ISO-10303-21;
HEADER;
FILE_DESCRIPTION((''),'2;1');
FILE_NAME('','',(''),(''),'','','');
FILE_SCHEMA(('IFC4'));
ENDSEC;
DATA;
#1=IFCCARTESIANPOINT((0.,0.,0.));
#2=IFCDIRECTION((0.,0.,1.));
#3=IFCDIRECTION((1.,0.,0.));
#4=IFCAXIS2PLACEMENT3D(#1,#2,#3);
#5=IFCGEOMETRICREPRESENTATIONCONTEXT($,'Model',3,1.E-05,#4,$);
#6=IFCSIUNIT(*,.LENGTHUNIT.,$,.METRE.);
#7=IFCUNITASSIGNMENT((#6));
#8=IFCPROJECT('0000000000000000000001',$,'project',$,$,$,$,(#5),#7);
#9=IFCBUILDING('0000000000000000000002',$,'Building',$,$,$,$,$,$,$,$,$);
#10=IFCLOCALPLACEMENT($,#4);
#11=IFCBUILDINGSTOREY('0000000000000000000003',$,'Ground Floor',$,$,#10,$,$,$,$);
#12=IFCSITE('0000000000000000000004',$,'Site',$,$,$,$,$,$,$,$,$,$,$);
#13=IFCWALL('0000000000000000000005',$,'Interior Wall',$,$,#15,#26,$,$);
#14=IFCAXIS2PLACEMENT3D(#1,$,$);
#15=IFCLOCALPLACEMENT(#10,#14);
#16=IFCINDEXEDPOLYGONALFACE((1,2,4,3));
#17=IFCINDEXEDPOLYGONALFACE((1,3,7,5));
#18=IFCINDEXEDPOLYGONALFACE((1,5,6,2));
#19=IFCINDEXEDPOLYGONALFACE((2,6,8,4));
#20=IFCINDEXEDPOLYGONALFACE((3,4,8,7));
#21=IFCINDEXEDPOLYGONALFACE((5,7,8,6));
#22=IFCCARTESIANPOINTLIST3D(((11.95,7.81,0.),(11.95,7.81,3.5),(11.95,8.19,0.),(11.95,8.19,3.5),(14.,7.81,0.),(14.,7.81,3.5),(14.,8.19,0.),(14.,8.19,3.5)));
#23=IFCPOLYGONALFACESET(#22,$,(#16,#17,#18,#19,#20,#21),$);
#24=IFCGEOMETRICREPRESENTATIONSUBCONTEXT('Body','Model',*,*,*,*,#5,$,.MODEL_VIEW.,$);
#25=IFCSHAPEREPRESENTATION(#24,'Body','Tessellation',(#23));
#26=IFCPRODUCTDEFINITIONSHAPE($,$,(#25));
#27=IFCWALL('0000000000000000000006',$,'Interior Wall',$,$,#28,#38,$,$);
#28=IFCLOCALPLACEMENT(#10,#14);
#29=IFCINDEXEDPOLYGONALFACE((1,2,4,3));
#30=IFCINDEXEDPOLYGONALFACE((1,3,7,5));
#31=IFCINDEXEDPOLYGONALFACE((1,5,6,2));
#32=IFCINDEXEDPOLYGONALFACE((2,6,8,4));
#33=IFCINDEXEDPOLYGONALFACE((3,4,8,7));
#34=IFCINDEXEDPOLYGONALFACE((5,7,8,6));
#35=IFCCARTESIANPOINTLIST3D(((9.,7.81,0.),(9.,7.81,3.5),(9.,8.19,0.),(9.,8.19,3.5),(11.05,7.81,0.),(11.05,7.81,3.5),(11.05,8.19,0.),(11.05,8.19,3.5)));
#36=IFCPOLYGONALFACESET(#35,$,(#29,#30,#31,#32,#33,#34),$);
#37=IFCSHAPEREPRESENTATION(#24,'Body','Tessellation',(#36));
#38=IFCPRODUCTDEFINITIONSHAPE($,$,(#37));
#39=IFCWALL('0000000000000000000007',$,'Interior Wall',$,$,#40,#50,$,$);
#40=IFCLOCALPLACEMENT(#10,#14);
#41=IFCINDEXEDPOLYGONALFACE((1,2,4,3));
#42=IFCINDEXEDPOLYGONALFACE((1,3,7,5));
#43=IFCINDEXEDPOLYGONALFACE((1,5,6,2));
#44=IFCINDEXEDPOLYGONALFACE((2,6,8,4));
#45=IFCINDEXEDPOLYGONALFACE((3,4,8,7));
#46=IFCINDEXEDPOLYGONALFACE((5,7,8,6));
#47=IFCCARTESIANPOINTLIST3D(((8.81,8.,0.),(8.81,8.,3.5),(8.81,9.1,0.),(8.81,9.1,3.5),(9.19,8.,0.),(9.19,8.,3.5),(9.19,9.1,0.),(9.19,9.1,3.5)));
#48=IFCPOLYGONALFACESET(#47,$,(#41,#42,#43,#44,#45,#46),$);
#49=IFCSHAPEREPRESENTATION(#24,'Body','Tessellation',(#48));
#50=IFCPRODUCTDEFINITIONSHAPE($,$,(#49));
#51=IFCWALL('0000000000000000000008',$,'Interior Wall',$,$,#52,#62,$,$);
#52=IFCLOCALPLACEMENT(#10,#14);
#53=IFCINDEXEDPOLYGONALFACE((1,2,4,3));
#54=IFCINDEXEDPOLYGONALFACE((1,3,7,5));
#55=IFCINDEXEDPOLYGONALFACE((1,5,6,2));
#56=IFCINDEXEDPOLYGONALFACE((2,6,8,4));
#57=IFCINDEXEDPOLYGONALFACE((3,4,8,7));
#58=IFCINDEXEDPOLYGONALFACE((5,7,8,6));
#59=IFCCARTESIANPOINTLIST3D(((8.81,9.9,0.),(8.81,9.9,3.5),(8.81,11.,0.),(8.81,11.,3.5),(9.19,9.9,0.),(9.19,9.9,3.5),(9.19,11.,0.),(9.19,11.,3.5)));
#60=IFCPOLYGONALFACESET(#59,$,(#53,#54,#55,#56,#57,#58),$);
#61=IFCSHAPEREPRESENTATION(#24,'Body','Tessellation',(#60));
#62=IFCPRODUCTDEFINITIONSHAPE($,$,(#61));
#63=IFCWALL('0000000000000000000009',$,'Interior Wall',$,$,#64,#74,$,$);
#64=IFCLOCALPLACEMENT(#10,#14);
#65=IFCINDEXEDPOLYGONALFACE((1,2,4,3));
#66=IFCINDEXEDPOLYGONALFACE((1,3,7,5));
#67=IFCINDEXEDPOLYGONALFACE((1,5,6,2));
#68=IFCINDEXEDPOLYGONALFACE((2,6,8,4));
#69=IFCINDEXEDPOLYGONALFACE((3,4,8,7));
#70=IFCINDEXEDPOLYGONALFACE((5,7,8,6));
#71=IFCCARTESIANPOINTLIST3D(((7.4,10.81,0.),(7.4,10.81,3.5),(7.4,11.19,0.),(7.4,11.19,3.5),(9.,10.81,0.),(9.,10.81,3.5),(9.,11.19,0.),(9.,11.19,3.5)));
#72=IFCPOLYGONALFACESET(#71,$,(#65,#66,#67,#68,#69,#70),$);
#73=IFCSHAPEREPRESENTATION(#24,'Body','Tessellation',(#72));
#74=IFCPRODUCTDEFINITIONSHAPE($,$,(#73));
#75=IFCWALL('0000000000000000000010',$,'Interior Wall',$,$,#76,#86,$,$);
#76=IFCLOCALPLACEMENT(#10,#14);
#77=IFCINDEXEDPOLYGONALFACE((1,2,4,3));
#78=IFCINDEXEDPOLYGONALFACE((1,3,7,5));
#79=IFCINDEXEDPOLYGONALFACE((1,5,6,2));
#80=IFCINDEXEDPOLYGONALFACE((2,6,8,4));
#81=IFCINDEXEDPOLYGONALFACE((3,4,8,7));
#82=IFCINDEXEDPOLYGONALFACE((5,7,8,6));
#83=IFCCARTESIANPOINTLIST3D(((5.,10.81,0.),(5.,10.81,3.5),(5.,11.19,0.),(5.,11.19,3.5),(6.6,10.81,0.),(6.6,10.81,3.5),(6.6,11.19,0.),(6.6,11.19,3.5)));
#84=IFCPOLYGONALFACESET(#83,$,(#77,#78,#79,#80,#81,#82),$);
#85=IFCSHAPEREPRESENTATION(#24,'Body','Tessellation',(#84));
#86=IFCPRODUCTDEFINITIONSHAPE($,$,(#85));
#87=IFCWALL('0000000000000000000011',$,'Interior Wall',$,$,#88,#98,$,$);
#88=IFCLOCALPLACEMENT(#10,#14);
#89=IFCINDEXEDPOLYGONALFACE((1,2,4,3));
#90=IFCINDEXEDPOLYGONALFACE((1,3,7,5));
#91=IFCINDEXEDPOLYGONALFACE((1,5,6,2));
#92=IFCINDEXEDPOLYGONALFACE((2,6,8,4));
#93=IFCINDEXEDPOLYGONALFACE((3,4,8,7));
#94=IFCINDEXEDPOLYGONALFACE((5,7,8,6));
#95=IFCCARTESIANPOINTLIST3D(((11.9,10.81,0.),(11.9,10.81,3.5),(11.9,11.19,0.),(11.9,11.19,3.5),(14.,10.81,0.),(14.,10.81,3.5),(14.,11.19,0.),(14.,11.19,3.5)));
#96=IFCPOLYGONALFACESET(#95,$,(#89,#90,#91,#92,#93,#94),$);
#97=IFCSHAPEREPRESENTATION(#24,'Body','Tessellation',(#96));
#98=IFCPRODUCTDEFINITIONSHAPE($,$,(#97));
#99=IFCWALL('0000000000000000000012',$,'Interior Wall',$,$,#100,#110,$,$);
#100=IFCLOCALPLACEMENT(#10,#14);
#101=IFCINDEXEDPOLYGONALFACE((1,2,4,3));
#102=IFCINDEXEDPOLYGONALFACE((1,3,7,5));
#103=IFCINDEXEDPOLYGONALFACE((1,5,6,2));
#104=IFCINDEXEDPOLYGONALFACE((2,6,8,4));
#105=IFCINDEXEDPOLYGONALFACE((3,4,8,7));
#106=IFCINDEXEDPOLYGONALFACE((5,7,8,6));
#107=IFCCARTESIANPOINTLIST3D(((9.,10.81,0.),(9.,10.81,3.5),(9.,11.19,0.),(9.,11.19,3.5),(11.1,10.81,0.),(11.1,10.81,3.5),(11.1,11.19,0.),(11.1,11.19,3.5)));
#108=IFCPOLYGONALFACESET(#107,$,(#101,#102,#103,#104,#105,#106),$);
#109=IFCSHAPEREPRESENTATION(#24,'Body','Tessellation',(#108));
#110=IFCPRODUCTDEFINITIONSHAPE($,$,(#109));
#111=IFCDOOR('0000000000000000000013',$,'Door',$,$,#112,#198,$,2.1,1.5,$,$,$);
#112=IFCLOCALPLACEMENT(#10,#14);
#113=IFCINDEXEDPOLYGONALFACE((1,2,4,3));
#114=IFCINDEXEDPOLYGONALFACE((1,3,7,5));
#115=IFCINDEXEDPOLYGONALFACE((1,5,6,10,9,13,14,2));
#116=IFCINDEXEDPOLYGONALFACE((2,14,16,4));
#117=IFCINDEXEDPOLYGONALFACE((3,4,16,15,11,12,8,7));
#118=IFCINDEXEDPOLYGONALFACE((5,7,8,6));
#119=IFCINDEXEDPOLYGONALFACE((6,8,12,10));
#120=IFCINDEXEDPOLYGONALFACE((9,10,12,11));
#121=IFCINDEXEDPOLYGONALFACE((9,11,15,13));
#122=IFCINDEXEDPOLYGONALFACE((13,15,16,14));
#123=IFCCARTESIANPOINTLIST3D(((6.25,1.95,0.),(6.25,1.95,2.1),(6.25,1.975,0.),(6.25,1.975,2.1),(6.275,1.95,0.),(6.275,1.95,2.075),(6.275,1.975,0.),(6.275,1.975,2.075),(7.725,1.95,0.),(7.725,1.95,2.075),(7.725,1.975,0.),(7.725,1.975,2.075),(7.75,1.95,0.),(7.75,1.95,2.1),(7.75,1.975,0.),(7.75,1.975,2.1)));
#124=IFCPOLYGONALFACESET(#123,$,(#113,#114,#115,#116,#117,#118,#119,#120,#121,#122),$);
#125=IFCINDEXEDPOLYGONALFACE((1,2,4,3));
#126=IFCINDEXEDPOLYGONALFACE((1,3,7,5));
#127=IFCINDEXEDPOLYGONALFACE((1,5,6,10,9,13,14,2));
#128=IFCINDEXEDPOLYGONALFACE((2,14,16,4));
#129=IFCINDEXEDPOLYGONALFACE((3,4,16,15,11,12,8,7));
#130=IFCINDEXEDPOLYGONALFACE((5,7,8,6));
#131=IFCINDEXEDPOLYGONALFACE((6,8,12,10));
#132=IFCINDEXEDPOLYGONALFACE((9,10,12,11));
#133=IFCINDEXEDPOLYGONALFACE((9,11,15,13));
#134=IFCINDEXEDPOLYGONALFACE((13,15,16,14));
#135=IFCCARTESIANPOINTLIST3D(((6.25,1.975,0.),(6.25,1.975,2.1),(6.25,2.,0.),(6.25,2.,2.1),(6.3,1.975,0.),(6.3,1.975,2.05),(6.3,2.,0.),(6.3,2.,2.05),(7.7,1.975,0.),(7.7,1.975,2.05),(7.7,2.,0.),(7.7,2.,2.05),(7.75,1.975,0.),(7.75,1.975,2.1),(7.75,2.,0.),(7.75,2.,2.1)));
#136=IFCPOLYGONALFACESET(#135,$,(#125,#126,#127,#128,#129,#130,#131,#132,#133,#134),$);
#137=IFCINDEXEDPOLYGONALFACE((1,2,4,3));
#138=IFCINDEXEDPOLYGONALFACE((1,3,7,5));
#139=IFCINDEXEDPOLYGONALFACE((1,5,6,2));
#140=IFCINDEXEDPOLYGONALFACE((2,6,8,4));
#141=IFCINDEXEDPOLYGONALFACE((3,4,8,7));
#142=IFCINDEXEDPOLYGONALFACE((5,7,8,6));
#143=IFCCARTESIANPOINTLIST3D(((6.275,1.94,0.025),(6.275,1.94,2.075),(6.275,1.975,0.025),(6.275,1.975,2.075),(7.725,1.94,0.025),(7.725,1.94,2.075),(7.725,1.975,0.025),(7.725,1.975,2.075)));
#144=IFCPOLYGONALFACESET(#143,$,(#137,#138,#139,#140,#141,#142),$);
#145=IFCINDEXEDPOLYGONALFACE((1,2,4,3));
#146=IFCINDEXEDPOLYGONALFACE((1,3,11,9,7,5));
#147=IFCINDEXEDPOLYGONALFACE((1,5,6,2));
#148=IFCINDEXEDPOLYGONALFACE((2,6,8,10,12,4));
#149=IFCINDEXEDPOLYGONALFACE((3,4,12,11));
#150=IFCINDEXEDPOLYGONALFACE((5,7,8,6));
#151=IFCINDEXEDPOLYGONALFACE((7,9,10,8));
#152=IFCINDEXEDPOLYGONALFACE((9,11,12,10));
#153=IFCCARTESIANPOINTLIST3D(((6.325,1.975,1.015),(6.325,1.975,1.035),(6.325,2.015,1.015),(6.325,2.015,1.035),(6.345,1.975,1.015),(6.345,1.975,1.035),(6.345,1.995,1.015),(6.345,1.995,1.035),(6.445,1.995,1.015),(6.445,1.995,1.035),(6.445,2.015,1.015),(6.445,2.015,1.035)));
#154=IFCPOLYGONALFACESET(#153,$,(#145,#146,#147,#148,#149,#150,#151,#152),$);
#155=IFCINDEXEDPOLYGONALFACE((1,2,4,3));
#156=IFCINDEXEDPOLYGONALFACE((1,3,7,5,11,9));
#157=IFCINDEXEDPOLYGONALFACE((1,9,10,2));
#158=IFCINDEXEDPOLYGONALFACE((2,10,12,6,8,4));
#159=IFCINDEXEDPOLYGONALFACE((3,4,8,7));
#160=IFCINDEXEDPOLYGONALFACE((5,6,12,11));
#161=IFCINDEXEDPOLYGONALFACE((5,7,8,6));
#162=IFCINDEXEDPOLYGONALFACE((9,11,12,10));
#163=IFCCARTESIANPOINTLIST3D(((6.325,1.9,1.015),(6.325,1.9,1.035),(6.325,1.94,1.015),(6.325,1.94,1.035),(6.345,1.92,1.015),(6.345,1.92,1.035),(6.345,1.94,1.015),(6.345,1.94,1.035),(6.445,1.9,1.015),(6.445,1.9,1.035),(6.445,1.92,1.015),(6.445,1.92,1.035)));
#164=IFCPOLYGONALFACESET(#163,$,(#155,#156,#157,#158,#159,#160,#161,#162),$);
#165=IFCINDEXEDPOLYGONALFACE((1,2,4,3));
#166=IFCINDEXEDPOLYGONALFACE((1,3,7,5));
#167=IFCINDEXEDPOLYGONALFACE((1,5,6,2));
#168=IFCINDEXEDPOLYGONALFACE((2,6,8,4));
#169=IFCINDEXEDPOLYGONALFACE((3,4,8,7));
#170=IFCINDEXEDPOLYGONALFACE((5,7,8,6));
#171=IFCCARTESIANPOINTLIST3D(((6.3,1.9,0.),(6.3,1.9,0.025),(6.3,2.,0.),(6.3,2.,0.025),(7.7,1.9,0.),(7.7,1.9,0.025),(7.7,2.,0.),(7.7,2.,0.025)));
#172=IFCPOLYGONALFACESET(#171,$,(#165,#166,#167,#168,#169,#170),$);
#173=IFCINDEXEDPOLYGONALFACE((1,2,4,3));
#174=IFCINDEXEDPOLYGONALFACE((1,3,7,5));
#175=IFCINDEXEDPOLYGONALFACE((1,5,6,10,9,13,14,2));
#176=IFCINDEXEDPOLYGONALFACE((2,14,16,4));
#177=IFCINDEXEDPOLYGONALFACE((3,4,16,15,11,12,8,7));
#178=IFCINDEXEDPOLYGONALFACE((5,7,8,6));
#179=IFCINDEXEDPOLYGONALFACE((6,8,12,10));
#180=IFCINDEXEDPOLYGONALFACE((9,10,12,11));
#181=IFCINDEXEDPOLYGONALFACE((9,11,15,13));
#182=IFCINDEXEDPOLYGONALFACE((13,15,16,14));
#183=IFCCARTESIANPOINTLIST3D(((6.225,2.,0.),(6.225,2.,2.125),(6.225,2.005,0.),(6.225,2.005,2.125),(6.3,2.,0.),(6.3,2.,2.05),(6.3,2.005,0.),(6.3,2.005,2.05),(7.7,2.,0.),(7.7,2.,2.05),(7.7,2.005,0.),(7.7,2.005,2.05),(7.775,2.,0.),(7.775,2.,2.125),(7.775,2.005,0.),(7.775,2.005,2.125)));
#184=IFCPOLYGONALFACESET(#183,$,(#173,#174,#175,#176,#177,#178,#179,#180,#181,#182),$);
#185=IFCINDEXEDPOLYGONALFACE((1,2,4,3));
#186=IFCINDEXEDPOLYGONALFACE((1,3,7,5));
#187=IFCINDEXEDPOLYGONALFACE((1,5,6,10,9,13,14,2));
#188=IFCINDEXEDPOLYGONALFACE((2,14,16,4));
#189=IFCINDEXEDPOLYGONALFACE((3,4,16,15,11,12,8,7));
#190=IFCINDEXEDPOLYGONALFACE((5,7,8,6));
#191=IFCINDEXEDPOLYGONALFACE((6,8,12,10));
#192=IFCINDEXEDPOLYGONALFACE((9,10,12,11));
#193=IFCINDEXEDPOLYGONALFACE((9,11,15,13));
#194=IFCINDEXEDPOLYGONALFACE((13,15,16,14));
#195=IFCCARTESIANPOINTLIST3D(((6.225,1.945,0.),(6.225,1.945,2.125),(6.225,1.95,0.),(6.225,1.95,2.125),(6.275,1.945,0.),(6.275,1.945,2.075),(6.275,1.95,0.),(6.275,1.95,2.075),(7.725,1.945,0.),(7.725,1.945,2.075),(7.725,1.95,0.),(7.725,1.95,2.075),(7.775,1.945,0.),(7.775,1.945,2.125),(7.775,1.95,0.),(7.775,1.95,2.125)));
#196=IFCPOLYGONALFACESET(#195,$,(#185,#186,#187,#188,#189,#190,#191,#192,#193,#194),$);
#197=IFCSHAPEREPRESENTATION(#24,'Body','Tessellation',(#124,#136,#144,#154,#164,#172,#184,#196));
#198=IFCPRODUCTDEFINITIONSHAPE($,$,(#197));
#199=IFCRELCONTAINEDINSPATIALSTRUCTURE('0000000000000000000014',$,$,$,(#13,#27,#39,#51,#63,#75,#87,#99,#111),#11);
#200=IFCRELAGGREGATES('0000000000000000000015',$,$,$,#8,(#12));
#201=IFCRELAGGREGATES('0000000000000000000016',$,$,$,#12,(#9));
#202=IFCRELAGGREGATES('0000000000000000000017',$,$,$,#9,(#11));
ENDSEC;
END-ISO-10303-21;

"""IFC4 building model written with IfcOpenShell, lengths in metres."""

from ifc_helpers import new_model, si_unit, frame, origin_with_axes, place, context, subcontext, project, spatial, line, indexed_curve, outline, extrude, element, save


model = new_model("IFC4")

# Units and contexts
model_context = context("Model", 3, precision=1e-05, world=origin_with_axes())
body_context = subcontext(model_context, "Body", "Model", "MODEL_VIEW")
ifc_project = project(units=[si_unit("LENGTHUNIT", "METRE")], contexts=[model_context])

# Site, building, storey
site = spatial("IfcSite", under=ifc_project, Name="Site")
building = spatial("IfcBuilding", under=site, Name="Building")
storey_placement = place(None, origin_with_axes())
storey = spatial("IfcBuildingStorey", under=building, at=storey_placement, Name="Ground Floor")

# Walls
for number, where, z_axis, x_axis, name in (
    (1, (14.0, 8.0, 0.0), (0.0, 0.0, 1.0), (-1.0, 0.0, 0.0), "Interior Wall"),
    (2, (11.05, 8.0, 0.0), (0.0, 0.0, 1.0), (-1.0, 0.0, 0.0), "Interior Wall"),
):
    element("IfcWall", number, at=place(storey_placement, frame(where, z_axis=z_axis, x_axis=x_axis)), inside=storey, Name=name, context=body_context, shape_type="SweptSolid", body=[
        extrude(outline(indexed_curve([(0.0, 0.0), (0.0, 0.38), (2.05, 0.38), (2.05, 0.0), (0.0, 0.0)], self_intersect=False)), frame((0.0, -0.19, 0.0), z_axis=(0.0, 0.0, 1.0), x_axis=(1.0, 0.0, 0.0)), (0.0, 0.0, 1.0), 3.5),
    ])
for number, where, z_axis, x_axis, name in (
    (3, (9.0, 8.0, 0.0), (0.0, 0.0, 1.0), (0.0, 1.0, 0.0), "Interior Wall"),
    (4, (9.0, 9.9, 0.0), (0.0, 0.0, 1.0), (0.0, 1.0, 0.0), "Interior Wall"),
):
    element("IfcWall", number, at=place(storey_placement, frame(where, z_axis=z_axis, x_axis=x_axis)), inside=storey, Name=name, context=body_context, shape_type="SweptSolid", body=[
        extrude(outline(indexed_curve([(0.0, 0.0), (0.0, 0.38), (1.1, 0.38), (1.1, 0.0), (0.0, 0.0)], self_intersect=False)), frame((0.0, -0.19, 0.0), z_axis=(0.0, 0.0, 1.0), x_axis=(1.0, 0.0, 0.0)), (0.0, 0.0, 1.0), 3.5),
    ])
for number, where, z_axis, x_axis, name in (
    (5, (9.0, 11.0, 0.0), (0.0, 0.0, 1.0), (-1.0, 0.0, 0.0), "Interior Wall"),
    (6, (6.6, 11.0, 0.0), (0.0, 0.0, 1.0), (-1.0, 0.0, 0.0), "Interior Wall"),
):
    element("IfcWall", number, at=place(storey_placement, frame(where, z_axis=z_axis, x_axis=x_axis)), inside=storey, Name=name, context=body_context, shape_type="SweptSolid", body=[
        extrude(outline(indexed_curve([(0.0, 0.0), (0.0, 0.38), (1.6, 0.38), (1.6, 0.0), (0.0, 0.0)], self_intersect=False)), frame((0.0, -0.19, 0.0), z_axis=(0.0, 0.0, 1.0), x_axis=(1.0, 0.0, 0.0)), (0.0, 0.0, 1.0), 3.5),
    ])
for number, where, z_axis, x_axis, name in (
    (7, (14.0, 11.0, 0.0), (0.0, 0.0, 1.0), (-1.0, 0.0, 0.0), "Interior Wall"),
    (8, (11.1, 11.0, 0.0), (0.0, 0.0, 1.0), (-1.0, 0.0, 0.0), "Interior Wall"),
):
    element("IfcWall", number, at=place(storey_placement, frame(where, z_axis=z_axis, x_axis=x_axis)), inside=storey, Name=name, context=body_context, shape_type="SweptSolid", body=[
        extrude(outline(indexed_curve([(0.0, 0.0), (0.0, 0.38), (2.1, 0.38), (2.1, 0.0), (0.0, 0.0)], self_intersect=False)), frame((0.0, -0.19, 0.0), z_axis=(0.0, 0.0, 1.0), x_axis=(1.0, 0.0, 0.0)), (0.0, 0.0, 1.0), 3.5),
    ])

# Door
door_1_placement = place(storey_placement, frame((7.75, 2.0, 0.0), z_axis=(0.0, 0.0, 1.0), x_axis=(-1.0, 0.0, 0.0)))
element("IfcDoor", 9, at=door_1_placement, inside=storey, Name="Door", OverallHeight=2.1, OverallWidth=1.5, context=body_context, shape_type="SweptSolid", body=[
    extrude(outline(indexed_curve([(0.0, 0.0), (0.0, 2.1), (1.5, 2.1), (1.5, 0.0), (1.475, 0.0), (1.475, 2.075), (0.025, 2.075), (0.025, 0.0)], segments=[line(1, 2, 3, 4, 5, 6, 7, 8, 1)])), frame((0.0, 0.025, 0.0), z_axis=(0.0, -1.0, 0.0), x_axis=(1.0, 0.0, 0.0)), (0.0, 0.0, -1.0), 0.025),
    extrude(outline(indexed_curve([(0.0, 0.0), (0.0, 2.1), (1.5, 2.1), (1.5, 0.0), (1.45, 0.0), (1.45, 2.05), (0.05, 2.05), (0.05, 0.0)], segments=[line(1, 2, 3, 4, 5, 6, 7, 8, 1)])), frame((0.0, 0.0, 0.0), z_axis=(0.0, -1.0, 0.0), x_axis=(1.0, 0.0, 0.0)), (0.0, 0.0, -1.0), 0.025),
    extrude(outline(indexed_curve([(0.0, 0.0), (1.45, 0.0), (1.45, 0.035), (0.0, 0.035)], segments=[line(1, 2, 3, 4, 1)])), frame((0.025, 0.025, 0.025), z_axis=(0.0, 0.0, 1.0), x_axis=(1.0, 0.0, 0.0)), (0.0, 0.0, 1.0), 2.05),
    extrude(outline(indexed_curve([(0.0, 0.0), (0.0, -0.04), (-0.12, -0.04), (-0.12, -0.02), (-0.02, -0.02), (-0.02, 0.0)], segments=[line(1, 2, 3, 4, 5, 6, 1)])), frame((1.425, 0.025, 1.015), z_axis=(0.0, 0.0, 1.0), x_axis=(1.0, 0.0, 0.0)), (0.0, 0.0, 1.0), 0.02),
    extrude(outline(indexed_curve([(0.0, 0.0), (0.0, 0.04), (-0.12, 0.04), (-0.12, 0.02), (-0.02, 0.02), (-0.02, 0.0)], segments=[line(1, 2, 3, 4, 5, 6, 1)])), frame((1.425, 0.06, 1.015), z_axis=(0.0, 0.0, 1.0), x_axis=(1.0, 0.0, 0.0)), (0.0, 0.0, 1.0), 0.02),
    extrude(outline(indexed_curve([(0.0, 0.0), (1.4, 0.0), (1.4, 0.1), (0.0, 0.1)], segments=[line(1, 2, 3, 4, 1)])), frame((0.05, 0.0, 0.0), z_axis=(0.0, 0.0, 1.0), x_axis=(1.0, 0.0, 0.0)), (0.0, 0.0, 1.0), 0.025),
    extrude(outline(indexed_curve([(0.0, 0.0), (0.0, 2.125), (1.55, 2.125), (1.55, 0.0), (1.475, 0.0), (1.475, 2.05), (0.075, 2.05), (0.075, 0.0)], segments=[line(1, 2, 3, 4, 5, 6, 7, 8, 1)])), frame((-0.025, -0.005, 0.0), z_axis=(0.0, -1.0, 0.0), x_axis=(1.0, 0.0, 0.0)), (0.0, 0.0, -1.0), 0.005),
    extrude(outline(indexed_curve([(0.0, 0.0), (0.0, 2.125), (1.55, 2.125), (1.55, 0.0), (1.5, 0.0), (1.5, 2.075), (0.05, 2.075), (0.05, 0.0)], segments=[line(1, 2, 3, 4, 5, 6, 7, 8, 1)])), frame((-0.025, 0.05, 0.0), z_axis=(0.0, -1.0, 0.0), x_axis=(1.0, 0.0, 0.0)), (0.0, 0.0, -1.0), 0.005),
])

save(model, "model.ifc")
